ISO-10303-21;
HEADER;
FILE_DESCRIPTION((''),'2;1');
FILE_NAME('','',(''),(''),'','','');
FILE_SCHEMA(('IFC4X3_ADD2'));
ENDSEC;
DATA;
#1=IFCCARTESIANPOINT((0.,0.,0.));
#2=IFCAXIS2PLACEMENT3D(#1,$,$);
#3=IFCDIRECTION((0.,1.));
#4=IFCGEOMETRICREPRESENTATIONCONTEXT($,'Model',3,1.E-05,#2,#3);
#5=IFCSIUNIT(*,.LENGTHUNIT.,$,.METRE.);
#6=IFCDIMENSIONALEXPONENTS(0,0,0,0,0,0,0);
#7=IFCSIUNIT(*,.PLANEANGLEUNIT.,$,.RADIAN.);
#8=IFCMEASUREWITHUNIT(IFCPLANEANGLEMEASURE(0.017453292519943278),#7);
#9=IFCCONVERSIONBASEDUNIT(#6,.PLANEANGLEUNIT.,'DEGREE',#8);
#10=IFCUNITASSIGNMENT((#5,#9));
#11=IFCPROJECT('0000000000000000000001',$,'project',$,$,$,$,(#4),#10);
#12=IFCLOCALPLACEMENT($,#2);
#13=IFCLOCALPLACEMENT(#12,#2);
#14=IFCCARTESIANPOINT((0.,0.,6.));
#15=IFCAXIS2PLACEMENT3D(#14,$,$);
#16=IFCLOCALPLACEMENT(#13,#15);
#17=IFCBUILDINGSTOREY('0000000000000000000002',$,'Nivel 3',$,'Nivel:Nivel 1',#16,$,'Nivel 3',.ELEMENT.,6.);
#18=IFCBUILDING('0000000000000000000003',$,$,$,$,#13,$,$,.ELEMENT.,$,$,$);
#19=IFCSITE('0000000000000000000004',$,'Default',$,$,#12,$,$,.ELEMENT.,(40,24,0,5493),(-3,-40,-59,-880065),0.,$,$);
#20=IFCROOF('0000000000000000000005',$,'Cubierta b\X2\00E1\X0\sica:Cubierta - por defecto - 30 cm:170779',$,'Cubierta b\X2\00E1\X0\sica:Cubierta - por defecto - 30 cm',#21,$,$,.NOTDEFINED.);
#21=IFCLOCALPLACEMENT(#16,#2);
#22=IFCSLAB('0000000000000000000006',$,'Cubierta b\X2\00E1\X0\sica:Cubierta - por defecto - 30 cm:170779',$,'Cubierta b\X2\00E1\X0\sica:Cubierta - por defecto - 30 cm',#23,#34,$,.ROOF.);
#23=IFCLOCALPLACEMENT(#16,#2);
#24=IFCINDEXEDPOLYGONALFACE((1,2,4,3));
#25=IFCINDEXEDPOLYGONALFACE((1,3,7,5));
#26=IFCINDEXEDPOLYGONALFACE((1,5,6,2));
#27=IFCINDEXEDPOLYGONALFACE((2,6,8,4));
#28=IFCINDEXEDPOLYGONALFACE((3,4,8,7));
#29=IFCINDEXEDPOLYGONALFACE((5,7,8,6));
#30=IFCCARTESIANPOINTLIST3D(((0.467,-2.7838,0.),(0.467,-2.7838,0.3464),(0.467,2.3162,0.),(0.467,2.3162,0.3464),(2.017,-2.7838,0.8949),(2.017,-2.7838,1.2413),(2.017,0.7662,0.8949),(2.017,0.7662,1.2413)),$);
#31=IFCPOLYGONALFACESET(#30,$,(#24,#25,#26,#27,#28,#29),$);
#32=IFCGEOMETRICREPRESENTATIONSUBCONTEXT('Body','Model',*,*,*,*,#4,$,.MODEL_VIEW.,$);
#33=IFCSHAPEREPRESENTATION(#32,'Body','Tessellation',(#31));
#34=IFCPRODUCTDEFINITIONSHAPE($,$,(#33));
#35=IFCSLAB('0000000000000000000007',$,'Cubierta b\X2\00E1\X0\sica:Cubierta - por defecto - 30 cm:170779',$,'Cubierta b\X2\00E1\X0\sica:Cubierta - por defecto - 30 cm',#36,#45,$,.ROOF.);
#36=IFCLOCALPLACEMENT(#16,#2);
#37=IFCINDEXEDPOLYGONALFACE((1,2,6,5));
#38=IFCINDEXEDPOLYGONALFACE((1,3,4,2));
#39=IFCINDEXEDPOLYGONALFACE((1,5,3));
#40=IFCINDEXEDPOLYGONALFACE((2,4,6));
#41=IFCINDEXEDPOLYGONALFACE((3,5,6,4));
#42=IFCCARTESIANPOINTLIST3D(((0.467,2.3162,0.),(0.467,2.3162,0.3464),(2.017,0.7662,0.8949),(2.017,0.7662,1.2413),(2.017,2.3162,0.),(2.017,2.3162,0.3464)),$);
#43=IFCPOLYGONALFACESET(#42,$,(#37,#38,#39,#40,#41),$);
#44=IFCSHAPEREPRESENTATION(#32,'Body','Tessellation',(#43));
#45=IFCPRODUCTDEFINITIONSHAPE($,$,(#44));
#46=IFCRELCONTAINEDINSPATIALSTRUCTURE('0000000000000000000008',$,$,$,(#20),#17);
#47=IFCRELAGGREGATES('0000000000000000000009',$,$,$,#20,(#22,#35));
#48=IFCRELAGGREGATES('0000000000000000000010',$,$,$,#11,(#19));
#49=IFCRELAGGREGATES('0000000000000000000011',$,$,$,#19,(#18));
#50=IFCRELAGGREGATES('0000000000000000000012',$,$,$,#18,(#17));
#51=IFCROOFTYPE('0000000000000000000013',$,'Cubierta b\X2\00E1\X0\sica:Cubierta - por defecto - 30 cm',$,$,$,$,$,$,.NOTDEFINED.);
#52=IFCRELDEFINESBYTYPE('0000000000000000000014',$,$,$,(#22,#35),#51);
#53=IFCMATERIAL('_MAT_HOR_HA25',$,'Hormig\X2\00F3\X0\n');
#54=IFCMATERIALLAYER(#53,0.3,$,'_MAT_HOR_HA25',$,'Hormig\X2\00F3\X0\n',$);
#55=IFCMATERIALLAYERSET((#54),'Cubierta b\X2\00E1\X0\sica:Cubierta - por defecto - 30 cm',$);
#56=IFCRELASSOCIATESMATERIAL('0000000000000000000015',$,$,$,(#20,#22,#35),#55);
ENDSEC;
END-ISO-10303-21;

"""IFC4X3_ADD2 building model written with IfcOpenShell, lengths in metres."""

from ifc_helpers import new_model, entity, si_unit, converted_unit, direction, frame, origin, place, context, subcontext, project, spatial, polyline, outline, extrude, material, layer, layer_set, type_object, element, aggregate, save


model = new_model("IFC4X3_ADD2")

# Units and contexts
model_context = context("Model", 3, precision=1e-05, world=origin(), true_north=direction((0.0, 1.0)))
body_context = subcontext(model_context, "Body", "Model", "MODEL_VIEW")
ifc_project = project(units=[si_unit("LENGTHUNIT", "METRE"), converted_unit("PLANEANGLEUNIT", "DEGREE", entity("IfcPlaneAngleMeasure", 0.017453292519943278), si_unit("PLANEANGLEUNIT", "RADIAN"), dimensions=[0, 0, 0, 0, 0, 0, 0])], contexts=[model_context])

# Site, building, storey
site_placement = place(None, origin())
site = spatial("IfcSite", under=ifc_project, at=site_placement, Name="Default", CompositionType="ELEMENT", RefLatitude=(40, 24, 0, 5493), RefLongitude=(-3, -40, -59, -880065), RefElevation=0.0)
building_placement = place(site_placement, origin())
building = spatial("IfcBuilding", under=site, at=building_placement, CompositionType="ELEMENT")
storey_placement = place(building_placement, frame((0.0, 0.0, 6.0)))
storey = spatial("IfcBuildingStorey", under=building, at=storey_placement, Name="Nivel 3", ObjectType="Nivel:Nivel 1", LongName="Nivel 3", CompositionType="ELEMENT", Elevation=6.0)

# Roof, slabs
ifc_material = material(Name="_MAT_HOR_HA25", Category="Hormigón")
ifc_layer = layer(ifc_material, 0.3, Name="_MAT_HOR_HA25", Category="Hormigón")
ifc_layer_set = layer_set([ifc_layer], Name="Cubierta básica:Cubierta - por defecto - 30 cm")
roof_placement = place(storey_placement, frame((0.467, -2.7838, 0.0)))
roof = element("IfcRoof", 1, at=roof_placement, inside=storey, material=ifc_layer_set, Name="Cubierta básica:Cubierta - por defecto - 30 cm:170779", ObjectType="Cubierta básica:Cubierta - por defecto - 30 cm", PredefinedType="NOTDEFINED")
roof_type = type_object("IfcRoofType", Name="Cubierta básica:Cubierta - por defecto - 30 cm", PredefinedType="NOTDEFINED")
slab_1_placement = place(roof_placement, origin())
slab_1 = element("IfcSlab", 2, at=slab_1_placement, type_object=roof_type, material=ifc_layer_set, Name="Cubierta básica:Cubierta - por defecto - 30 cm:170779", ObjectType="Cubierta básica:Cubierta - por defecto - 30 cm", PredefinedType="ROOF", context=body_context, shape_type="SweptSolid", body=[
    extrude(outline(polyline([(0.8949, 1.0), (-0.8949, 2.55), (-0.8949, -2.55), (0.8949, -2.55), (0.8949, 1.0)])), frame((0.775, 2.55, 0.4474), z_axis=(-0.5, 0.0, 0.866025), x_axis=(0.866025, 0.0, 0.5)), (0.5, 0.0, 0.866025), 0.3464),
])
slab_2_placement = place(roof_placement, origin())
slab_2 = element("IfcSlab", 3, at=slab_2_placement, type_object=roof_type, material=ifc_layer_set, Name="Cubierta básica:Cubierta - por defecto - 30 cm:170779", ObjectType="Cubierta básica:Cubierta - por defecto - 30 cm", PredefinedType="ROOF", context=body_context, shape_type="SweptSolid", body=[
    extrude(outline(polyline([(-0.775, 0.8949), (0.775, -0.8949), (0.775, 0.8949), (-0.775, 0.8949)])), frame((0.775, 4.325, 0.4474), z_axis=(0.0, 0.5, 0.866025), x_axis=(1.0, 0.0, 0.0)), (0.0, -0.5, 0.866025), 0.3464),
])
aggregate(roof, [slab_1, slab_2])

save(model, "model.ifc")
